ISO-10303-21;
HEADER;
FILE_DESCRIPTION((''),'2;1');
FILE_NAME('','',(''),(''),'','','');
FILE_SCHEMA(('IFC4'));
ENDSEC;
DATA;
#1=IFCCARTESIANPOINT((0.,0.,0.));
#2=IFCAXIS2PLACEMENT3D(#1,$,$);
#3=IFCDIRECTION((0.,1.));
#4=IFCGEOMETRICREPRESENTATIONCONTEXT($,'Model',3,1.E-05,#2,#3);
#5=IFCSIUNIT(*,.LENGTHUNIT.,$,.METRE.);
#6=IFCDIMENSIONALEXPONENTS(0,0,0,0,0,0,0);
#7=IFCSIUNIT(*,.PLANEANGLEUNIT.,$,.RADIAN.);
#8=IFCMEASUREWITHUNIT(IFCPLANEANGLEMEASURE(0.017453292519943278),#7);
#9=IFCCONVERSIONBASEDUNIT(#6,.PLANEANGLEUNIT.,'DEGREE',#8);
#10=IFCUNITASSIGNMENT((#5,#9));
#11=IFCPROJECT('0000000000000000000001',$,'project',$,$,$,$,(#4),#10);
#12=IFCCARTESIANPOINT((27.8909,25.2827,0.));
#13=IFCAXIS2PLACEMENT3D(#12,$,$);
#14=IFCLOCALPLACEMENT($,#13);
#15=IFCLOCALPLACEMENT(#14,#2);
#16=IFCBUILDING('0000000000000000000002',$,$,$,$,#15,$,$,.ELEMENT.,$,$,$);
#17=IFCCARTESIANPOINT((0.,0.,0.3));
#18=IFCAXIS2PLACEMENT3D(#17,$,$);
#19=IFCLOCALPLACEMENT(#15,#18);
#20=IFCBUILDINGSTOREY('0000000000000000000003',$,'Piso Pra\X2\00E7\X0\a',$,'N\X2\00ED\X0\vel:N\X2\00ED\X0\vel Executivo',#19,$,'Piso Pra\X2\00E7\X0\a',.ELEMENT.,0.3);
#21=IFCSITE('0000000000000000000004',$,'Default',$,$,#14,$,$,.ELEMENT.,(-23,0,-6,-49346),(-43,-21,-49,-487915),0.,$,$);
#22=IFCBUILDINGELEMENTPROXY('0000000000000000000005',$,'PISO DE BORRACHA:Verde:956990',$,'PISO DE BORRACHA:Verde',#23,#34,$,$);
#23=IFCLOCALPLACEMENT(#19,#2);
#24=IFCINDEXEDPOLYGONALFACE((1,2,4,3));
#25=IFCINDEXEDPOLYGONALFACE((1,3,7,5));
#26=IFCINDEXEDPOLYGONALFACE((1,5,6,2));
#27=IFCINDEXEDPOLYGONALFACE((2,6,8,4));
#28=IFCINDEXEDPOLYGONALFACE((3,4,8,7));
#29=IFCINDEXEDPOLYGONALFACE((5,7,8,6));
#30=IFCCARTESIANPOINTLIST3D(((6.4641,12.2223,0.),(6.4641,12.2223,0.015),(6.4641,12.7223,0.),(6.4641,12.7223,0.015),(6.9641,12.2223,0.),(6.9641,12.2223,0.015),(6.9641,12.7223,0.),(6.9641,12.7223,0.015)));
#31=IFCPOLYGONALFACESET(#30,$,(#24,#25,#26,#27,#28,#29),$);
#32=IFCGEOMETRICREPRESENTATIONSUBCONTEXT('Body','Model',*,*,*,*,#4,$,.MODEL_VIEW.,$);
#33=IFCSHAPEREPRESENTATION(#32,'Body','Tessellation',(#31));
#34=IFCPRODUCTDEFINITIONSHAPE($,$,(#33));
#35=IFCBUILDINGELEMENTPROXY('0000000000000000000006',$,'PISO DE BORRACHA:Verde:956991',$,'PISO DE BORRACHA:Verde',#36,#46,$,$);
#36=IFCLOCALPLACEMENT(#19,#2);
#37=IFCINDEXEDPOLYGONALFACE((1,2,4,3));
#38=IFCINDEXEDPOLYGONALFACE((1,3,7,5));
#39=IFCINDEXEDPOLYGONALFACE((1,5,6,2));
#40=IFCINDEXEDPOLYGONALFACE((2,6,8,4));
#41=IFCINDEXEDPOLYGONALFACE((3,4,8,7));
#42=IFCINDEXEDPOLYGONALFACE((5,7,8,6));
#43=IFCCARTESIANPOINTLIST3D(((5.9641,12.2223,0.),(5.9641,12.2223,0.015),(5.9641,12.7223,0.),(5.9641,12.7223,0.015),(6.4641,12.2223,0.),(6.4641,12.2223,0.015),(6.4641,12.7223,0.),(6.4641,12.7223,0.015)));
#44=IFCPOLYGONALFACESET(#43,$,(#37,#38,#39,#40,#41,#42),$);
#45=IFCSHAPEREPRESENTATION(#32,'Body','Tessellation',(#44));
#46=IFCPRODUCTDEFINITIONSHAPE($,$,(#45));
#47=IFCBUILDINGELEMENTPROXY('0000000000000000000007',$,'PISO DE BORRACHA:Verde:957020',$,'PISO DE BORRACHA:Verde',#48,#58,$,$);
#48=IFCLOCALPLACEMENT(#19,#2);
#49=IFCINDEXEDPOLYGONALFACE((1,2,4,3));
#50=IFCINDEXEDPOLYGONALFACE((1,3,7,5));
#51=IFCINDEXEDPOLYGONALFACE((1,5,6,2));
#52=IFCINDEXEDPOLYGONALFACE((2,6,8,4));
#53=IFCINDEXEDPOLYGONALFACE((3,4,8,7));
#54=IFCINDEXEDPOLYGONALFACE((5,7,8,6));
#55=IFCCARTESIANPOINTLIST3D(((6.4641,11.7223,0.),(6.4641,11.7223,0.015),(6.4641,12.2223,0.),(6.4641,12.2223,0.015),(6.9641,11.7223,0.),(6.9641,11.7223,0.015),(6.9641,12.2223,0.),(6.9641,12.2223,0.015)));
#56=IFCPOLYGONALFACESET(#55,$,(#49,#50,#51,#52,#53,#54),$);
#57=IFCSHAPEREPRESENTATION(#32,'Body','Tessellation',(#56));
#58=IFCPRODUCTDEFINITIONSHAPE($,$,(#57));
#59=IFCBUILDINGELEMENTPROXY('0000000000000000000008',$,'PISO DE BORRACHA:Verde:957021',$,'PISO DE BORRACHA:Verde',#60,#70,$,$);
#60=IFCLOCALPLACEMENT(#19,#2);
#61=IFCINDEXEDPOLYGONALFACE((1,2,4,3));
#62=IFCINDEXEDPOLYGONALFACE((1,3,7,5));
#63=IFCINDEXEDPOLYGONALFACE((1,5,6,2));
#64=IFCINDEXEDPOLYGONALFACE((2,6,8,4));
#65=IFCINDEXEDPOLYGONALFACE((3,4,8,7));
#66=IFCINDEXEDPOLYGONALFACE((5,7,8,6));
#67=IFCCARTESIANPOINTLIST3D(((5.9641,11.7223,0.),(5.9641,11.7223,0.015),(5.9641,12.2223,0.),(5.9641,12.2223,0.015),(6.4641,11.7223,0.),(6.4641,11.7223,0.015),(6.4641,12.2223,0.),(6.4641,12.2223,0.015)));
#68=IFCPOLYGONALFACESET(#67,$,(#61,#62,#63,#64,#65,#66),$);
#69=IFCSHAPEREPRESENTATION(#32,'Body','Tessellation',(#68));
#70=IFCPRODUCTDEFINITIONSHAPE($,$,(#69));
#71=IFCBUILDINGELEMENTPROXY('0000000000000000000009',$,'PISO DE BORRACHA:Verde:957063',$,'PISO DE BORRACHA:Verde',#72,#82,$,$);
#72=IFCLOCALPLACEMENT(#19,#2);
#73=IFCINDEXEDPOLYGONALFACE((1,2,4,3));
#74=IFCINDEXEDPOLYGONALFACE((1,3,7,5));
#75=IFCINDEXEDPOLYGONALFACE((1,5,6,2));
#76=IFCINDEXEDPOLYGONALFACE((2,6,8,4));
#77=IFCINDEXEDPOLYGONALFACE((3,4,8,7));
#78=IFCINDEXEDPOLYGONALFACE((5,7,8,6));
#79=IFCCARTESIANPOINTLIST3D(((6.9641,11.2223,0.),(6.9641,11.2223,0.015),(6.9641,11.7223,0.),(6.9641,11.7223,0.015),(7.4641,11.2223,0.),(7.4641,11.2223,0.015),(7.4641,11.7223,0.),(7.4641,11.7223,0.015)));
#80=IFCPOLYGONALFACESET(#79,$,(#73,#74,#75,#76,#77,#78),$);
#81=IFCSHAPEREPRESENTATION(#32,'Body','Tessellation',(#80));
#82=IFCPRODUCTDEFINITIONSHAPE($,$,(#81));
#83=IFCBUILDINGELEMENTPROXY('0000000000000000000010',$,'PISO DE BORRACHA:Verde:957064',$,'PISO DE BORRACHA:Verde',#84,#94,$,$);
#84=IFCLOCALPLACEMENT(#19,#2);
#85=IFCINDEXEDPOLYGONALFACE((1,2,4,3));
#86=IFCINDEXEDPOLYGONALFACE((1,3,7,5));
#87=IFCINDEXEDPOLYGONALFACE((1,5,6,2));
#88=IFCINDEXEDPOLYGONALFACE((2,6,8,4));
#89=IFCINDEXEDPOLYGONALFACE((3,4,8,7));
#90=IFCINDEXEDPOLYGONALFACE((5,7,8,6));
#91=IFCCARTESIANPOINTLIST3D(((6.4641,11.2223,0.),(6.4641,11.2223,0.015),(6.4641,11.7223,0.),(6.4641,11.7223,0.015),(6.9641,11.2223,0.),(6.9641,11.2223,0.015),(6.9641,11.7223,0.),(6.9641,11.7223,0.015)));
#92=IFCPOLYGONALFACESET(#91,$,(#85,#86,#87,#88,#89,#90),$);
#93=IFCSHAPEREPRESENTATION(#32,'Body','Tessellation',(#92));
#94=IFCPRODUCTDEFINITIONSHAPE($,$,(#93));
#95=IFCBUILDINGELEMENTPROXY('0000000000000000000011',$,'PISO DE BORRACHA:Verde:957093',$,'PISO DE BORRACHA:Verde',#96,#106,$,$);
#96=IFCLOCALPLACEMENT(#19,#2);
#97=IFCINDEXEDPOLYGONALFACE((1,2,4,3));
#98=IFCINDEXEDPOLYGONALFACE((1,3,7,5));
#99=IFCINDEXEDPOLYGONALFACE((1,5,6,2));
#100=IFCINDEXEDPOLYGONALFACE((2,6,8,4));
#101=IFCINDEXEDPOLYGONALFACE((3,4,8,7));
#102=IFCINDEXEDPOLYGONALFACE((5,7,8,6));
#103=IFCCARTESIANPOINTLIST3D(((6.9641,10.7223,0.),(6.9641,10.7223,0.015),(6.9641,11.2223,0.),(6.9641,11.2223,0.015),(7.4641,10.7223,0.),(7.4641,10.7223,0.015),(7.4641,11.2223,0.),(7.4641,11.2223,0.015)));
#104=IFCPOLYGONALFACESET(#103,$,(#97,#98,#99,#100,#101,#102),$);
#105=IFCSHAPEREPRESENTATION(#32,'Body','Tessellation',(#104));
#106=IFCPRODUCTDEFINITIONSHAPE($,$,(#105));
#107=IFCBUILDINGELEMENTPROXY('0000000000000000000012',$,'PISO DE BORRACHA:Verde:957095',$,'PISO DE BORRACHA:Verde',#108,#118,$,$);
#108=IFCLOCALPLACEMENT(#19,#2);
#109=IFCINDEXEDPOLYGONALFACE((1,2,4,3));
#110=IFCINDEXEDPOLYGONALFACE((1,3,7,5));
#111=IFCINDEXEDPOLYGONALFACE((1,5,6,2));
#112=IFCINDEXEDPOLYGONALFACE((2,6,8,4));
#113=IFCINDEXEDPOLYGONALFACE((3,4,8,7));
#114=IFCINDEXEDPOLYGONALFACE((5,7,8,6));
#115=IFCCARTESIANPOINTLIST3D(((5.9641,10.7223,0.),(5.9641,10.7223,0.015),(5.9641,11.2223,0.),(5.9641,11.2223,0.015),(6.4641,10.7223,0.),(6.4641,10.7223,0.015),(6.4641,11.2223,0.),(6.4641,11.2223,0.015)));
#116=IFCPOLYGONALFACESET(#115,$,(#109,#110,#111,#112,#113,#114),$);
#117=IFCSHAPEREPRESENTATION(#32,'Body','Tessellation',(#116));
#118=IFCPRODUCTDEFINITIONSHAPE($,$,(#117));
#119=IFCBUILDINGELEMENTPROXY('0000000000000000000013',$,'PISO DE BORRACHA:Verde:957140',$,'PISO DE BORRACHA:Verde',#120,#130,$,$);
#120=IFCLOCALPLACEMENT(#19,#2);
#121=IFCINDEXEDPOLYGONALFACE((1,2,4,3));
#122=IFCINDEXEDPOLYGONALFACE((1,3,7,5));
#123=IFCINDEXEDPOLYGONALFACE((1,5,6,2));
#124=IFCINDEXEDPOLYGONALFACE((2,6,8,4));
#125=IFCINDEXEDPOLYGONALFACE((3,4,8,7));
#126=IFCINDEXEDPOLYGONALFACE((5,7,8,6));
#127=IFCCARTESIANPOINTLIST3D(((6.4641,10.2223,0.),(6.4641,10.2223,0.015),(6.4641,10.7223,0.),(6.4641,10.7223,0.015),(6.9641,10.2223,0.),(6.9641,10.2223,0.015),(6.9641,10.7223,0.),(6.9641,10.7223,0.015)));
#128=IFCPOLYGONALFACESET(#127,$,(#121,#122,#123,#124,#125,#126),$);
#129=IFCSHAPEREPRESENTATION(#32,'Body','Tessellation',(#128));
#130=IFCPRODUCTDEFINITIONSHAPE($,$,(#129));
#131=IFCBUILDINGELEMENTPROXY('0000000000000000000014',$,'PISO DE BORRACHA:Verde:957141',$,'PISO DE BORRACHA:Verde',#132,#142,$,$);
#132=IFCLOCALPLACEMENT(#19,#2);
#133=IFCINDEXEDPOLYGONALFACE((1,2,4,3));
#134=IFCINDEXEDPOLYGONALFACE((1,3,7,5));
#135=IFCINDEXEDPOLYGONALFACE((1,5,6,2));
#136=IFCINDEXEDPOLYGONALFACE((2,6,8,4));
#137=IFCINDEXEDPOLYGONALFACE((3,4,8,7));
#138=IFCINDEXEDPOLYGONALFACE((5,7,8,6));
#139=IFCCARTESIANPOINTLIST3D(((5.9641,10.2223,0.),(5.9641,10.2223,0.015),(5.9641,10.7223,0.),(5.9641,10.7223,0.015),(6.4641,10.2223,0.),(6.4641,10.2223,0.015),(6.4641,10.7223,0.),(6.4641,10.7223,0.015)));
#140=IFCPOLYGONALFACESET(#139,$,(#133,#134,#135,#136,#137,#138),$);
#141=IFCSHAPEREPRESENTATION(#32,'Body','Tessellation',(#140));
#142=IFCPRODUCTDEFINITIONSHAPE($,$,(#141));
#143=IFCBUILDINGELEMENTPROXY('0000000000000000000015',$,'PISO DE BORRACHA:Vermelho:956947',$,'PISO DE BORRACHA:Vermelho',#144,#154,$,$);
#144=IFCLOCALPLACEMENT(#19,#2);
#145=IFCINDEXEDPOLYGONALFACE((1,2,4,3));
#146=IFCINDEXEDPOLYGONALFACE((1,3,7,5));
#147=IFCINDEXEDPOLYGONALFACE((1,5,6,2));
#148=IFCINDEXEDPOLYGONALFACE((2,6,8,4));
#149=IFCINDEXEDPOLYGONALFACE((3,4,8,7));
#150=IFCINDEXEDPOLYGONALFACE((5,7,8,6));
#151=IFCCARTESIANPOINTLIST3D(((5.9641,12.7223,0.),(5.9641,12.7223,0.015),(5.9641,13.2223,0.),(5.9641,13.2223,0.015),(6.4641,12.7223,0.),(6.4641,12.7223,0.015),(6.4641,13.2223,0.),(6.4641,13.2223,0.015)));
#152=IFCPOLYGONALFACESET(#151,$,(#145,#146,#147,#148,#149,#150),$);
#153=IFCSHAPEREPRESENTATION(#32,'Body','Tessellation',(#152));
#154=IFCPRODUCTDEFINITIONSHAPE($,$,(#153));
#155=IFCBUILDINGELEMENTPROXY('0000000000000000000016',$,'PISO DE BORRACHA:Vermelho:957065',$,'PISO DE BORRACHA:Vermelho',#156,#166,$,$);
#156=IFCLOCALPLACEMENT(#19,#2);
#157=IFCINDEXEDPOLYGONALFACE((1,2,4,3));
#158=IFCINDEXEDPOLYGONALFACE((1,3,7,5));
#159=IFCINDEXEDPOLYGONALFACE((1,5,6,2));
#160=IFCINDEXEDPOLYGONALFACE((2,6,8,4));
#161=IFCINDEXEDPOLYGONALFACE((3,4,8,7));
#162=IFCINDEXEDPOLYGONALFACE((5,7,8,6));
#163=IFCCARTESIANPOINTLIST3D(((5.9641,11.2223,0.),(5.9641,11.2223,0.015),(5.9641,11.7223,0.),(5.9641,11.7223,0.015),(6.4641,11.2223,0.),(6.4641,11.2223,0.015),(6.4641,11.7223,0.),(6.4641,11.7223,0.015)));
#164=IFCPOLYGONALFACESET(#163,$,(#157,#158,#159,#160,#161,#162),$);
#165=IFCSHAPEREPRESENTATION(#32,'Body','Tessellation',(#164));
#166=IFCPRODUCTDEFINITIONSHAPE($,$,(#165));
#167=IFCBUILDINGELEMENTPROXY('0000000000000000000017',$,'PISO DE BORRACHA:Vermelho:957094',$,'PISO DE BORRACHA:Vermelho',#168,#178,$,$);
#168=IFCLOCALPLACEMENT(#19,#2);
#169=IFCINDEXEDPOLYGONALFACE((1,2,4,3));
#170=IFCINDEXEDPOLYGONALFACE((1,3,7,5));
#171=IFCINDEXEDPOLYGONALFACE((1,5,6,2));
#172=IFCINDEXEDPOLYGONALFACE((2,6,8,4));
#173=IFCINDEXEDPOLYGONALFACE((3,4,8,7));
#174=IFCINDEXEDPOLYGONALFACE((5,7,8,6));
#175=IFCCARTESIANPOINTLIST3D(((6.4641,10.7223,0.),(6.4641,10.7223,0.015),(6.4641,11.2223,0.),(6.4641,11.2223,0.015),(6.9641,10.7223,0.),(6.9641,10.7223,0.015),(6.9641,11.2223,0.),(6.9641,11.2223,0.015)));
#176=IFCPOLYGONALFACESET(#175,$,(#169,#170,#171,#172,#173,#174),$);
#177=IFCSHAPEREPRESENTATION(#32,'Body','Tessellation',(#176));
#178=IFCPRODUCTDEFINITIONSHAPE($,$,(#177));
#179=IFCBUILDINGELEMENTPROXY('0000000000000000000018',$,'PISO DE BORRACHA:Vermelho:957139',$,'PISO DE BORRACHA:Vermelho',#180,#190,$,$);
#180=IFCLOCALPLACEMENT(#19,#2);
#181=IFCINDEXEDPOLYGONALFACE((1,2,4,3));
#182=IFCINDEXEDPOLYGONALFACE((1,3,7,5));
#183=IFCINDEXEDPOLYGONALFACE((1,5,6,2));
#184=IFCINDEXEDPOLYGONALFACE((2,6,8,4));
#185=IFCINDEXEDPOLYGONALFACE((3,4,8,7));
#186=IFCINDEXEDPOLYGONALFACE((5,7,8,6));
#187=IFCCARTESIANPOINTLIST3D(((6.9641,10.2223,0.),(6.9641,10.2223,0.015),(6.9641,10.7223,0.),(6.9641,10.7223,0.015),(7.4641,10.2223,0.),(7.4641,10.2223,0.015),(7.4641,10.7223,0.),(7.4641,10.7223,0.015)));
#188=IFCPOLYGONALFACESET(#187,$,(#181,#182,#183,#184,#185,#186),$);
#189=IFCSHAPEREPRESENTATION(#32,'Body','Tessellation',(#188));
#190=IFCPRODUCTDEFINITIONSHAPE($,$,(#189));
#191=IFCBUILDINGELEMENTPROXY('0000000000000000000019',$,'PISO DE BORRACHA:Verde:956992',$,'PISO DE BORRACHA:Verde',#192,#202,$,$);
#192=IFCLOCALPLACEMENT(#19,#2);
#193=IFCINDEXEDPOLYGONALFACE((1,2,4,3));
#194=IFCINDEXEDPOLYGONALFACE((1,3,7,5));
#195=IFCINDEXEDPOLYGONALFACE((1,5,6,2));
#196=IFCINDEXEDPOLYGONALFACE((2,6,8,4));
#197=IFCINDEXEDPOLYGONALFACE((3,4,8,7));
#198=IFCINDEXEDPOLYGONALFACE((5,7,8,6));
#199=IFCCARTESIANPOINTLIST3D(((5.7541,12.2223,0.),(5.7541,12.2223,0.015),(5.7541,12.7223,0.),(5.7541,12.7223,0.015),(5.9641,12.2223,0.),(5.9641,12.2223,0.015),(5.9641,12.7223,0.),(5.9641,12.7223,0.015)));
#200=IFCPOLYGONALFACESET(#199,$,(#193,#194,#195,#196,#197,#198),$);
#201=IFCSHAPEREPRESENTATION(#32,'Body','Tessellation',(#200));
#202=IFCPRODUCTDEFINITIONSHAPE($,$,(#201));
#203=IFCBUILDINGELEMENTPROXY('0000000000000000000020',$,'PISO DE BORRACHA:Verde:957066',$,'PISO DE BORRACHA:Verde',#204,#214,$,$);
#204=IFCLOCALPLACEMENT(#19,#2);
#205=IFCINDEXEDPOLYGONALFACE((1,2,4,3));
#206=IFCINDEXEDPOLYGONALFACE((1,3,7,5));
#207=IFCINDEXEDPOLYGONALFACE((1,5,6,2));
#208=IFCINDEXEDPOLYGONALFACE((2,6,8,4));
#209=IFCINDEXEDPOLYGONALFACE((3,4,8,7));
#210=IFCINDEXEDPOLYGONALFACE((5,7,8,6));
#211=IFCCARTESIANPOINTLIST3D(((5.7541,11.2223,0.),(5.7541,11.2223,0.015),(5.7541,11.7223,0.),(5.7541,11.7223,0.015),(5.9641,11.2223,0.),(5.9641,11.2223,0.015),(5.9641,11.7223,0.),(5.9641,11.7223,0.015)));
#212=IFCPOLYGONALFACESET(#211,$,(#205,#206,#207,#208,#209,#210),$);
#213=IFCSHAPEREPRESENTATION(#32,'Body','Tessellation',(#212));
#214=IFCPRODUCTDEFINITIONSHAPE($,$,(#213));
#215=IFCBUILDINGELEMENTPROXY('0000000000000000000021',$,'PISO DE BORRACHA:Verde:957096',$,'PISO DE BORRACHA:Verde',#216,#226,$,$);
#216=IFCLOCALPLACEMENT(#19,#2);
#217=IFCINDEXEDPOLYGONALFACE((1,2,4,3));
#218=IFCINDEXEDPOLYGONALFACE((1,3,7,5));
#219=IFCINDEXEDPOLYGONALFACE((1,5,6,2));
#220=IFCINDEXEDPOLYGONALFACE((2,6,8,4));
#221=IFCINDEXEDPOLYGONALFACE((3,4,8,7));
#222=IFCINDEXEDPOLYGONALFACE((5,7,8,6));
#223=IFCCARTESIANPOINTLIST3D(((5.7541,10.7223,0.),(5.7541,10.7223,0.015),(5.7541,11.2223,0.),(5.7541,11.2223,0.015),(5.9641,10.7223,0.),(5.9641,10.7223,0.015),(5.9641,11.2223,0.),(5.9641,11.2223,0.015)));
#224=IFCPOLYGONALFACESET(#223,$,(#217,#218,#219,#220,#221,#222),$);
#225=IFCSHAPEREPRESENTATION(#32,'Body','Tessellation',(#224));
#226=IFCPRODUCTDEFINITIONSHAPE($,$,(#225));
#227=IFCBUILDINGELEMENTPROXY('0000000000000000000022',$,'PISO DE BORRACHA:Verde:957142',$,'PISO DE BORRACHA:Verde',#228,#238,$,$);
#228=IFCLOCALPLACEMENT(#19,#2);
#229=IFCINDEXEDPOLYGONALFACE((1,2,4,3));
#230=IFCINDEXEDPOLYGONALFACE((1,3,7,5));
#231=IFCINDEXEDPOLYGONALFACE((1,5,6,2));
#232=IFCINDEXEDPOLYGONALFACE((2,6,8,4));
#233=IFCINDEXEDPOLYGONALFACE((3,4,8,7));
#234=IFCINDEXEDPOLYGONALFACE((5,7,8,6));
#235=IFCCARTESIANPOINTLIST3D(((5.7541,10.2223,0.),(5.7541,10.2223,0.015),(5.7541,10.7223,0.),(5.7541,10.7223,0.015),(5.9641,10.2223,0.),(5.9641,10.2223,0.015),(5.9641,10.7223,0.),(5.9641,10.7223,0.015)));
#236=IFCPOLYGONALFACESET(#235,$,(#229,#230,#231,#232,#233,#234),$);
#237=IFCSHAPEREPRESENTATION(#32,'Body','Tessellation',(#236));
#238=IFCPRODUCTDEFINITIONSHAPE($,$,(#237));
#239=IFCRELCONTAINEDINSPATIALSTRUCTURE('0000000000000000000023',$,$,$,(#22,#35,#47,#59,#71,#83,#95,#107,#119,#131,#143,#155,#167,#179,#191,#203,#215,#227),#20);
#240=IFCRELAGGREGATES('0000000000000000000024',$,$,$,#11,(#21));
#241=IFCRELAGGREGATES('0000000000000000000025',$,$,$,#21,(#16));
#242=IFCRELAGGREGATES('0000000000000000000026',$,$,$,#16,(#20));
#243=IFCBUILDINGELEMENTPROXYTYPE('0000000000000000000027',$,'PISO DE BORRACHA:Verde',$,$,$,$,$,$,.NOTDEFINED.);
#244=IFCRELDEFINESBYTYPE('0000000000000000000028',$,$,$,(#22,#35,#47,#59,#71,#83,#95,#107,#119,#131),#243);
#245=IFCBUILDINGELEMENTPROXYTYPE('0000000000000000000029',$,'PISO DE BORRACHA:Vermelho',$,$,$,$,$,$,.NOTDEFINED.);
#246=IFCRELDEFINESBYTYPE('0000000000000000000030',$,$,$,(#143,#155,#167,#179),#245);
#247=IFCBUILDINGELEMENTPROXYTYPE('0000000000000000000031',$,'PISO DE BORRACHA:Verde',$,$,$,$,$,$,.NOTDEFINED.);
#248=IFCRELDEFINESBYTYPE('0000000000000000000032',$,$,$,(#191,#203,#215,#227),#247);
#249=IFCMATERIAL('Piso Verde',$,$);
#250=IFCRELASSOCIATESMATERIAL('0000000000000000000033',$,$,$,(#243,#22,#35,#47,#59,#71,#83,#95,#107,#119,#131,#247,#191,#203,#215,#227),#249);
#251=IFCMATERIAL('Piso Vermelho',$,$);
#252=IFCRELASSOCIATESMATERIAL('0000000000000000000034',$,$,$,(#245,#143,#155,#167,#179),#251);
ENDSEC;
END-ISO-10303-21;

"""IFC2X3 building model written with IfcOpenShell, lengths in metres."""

from ifc_helpers import new_model, entity, si_unit, converted_unit, direction, frame, frame_2d, origin, origin_2d_with_axis, place, context, subcontext, project, spatial, rectangle, extrude, source, transform, mapped, material, type_object, type_shapes, element, save


model = new_model("IFC2X3")

# Units and contexts
model_context = context("Model", 3, precision=1e-05, world=origin(), true_north=direction((0.0, 1.0)))
body_context = subcontext(model_context, "Body", "Model", "MODEL_VIEW")
ifc_project = project(units=[si_unit("LENGTHUNIT", "METRE"), converted_unit("PLANEANGLEUNIT", "DEGREE", entity("IfcPlaneAngleMeasure", 0.017453292519943278), si_unit("PLANEANGLEUNIT", "RADIAN"), dimensions=[0, 0, 0, 0, 0, 0, 0])], contexts=[model_context])

# Site, building, storey
site_placement = place(None, frame((27.8909, 25.2827, 0.0)))
site = spatial("IfcSite", under=ifc_project, at=site_placement, Name="Default", CompositionType="ELEMENT", RefLatitude=(-23, 0, -6, -49346), RefLongitude=(-43, -21, -49, -487915), RefElevation=0.0)
building_placement = place(site_placement, origin())
building = spatial("IfcBuilding", under=site, at=building_placement, CompositionType="ELEMENT")
storey_placement = place(building_placement, frame((0.0, 0.0, 0.3)))
storey = spatial("IfcBuildingStorey", under=building, at=storey_placement, Name="Piso Praça", ObjectType="Nível:Nível Executivo", LongName="Piso Praça", CompositionType="ELEMENT", Elevation=0.3)

# Building element proxies
ifc_material_1 = material(Name="Piso Verde")
building_element_proxy_type_1 = type_object("IfcBuildingElementProxyType", Name="PISO DE BORRACHA:Verde", PredefinedType="NOTDEFINED", material=ifc_material_1)
shared_shape_1 = source(origin(), body_context, "Body", "SweptSolid", [
    extrude(rectangle(XDim=0.5, YDim=0.5, at=origin_2d_with_axis()), frame((0.25, 0.25, 0.0), z_axis=(0.0, 0.0, 1.0), x_axis=(-1.0, 0.0, 0.0)), (0.0, 0.0, 1.0), 0.015),
])
type_shapes(building_element_proxy_type_1, [shared_shape_1])
for number, where, name in (
    (1, (6.4641, 12.2223, 0.0), "PISO DE BORRACHA:Verde:956990"),
    (2, (5.9641, 12.2223, 0.0), "PISO DE BORRACHA:Verde:956991"),
    (3, (6.4641, 11.7223, 0.0), "PISO DE BORRACHA:Verde:957020"),
    (4, (5.9641, 11.7223, 0.0), "PISO DE BORRACHA:Verde:957021"),
    (5, (6.9641, 11.2223, 0.0), "PISO DE BORRACHA:Verde:957063"),
    (6, (6.4641, 11.2223, 0.0), "PISO DE BORRACHA:Verde:957064"),
    (7, (6.9641, 10.7223, 0.0), "PISO DE BORRACHA:Verde:957093"),
    (8, (5.9641, 10.7223, 0.0), "PISO DE BORRACHA:Verde:957095"),
    (9, (6.4641, 10.2223, 0.0), "PISO DE BORRACHA:Verde:957140"),
    (10, (5.9641, 10.2223, 0.0), "PISO DE BORRACHA:Verde:957141"),
):
    element("IfcBuildingElementProxy", number, at=place(storey_placement, frame(where)), inside=storey, type_object=building_element_proxy_type_1, material=ifc_material_1, Name=name, ObjectType="PISO DE BORRACHA:Verde", context=body_context, shape_type="MappedRepresentation", body=[
        mapped(shared_shape_1, transform((0.0, 0.0, 0.0), scale=1.0)),
    ])
ifc_material_2 = material(Name="Piso Vermelho")
building_element_proxy_type_2 = type_object("IfcBuildingElementProxyType", Name="PISO DE BORRACHA:Vermelho", PredefinedType="NOTDEFINED", material=ifc_material_2)
shared_shape_2 = source(origin(), body_context, "Body", "SweptSolid", [
    extrude(rectangle(XDim=0.5, YDim=0.5, at=origin_2d_with_axis()), frame((0.25, 0.25, 0.0), z_axis=(0.0, 0.0, 1.0), x_axis=(-1.0, 0.0, 0.0)), (0.0, 0.0, 1.0), 0.015),
])
type_shapes(building_element_proxy_type_2, [shared_shape_2])
for number, where, name in (
    (11, (5.9641, 12.7223, 0.0), "PISO DE BORRACHA:Vermelho:956947"),
    (12, (5.9641, 11.2223, 0.0), "PISO DE BORRACHA:Vermelho:957065"),
    (13, (6.4641, 10.7223, 0.0), "PISO DE BORRACHA:Vermelho:957094"),
    (14, (6.9641, 10.2223, 0.0), "PISO DE BORRACHA:Vermelho:957139"),
):
    element("IfcBuildingElementProxy", number, at=place(storey_placement, frame(where)), inside=storey, type_object=building_element_proxy_type_2, material=ifc_material_2, Name=name, ObjectType="PISO DE BORRACHA:Vermelho", context=body_context, shape_type="MappedRepresentation", body=[
        mapped(shared_shape_2, transform((0.0, 0.0, 0.0), scale=1.0)),
    ])
building_element_proxy_type_3 = type_object("IfcBuildingElementProxyType", Name="PISO DE BORRACHA:Verde", PredefinedType="NOTDEFINED", material=ifc_material_1)
shared_shape_3 = source(origin(), body_context, "Body", "SweptSolid", [
    extrude(rectangle(XDim=0.21, YDim=0.5, at=frame_2d((0.0, 0.0), x_axis=(1.0, 0.0))), frame((0.105, 0.25, 0.0), z_axis=(0.0, 0.0, 1.0), x_axis=(-1.0, 0.0, 0.0)), (0.0, 0.0, 1.0), 0.015),
])
type_shapes(building_element_proxy_type_3, [shared_shape_3])
for number, where, name in (
    (15, (5.7541, 12.2223, 0.0), "PISO DE BORRACHA:Verde:956992"),
    (16, (5.7541, 11.2223, 0.0), "PISO DE BORRACHA:Verde:957066"),
    (17, (5.7541, 10.7223, 0.0), "PISO DE BORRACHA:Verde:957096"),
    (18, (5.7541, 10.2223, 0.0), "PISO DE BORRACHA:Verde:957142"),
):
    element("IfcBuildingElementProxy", number, at=place(storey_placement, frame(where)), inside=storey, type_object=building_element_proxy_type_3, material=ifc_material_1, Name=name, ObjectType="PISO DE BORRACHA:Verde", context=body_context, shape_type="MappedRepresentation", body=[
        mapped(shared_shape_3, transform((0.0, 0.0, 0.0), scale=1.0)),
    ])

save(model, "model.ifc")
